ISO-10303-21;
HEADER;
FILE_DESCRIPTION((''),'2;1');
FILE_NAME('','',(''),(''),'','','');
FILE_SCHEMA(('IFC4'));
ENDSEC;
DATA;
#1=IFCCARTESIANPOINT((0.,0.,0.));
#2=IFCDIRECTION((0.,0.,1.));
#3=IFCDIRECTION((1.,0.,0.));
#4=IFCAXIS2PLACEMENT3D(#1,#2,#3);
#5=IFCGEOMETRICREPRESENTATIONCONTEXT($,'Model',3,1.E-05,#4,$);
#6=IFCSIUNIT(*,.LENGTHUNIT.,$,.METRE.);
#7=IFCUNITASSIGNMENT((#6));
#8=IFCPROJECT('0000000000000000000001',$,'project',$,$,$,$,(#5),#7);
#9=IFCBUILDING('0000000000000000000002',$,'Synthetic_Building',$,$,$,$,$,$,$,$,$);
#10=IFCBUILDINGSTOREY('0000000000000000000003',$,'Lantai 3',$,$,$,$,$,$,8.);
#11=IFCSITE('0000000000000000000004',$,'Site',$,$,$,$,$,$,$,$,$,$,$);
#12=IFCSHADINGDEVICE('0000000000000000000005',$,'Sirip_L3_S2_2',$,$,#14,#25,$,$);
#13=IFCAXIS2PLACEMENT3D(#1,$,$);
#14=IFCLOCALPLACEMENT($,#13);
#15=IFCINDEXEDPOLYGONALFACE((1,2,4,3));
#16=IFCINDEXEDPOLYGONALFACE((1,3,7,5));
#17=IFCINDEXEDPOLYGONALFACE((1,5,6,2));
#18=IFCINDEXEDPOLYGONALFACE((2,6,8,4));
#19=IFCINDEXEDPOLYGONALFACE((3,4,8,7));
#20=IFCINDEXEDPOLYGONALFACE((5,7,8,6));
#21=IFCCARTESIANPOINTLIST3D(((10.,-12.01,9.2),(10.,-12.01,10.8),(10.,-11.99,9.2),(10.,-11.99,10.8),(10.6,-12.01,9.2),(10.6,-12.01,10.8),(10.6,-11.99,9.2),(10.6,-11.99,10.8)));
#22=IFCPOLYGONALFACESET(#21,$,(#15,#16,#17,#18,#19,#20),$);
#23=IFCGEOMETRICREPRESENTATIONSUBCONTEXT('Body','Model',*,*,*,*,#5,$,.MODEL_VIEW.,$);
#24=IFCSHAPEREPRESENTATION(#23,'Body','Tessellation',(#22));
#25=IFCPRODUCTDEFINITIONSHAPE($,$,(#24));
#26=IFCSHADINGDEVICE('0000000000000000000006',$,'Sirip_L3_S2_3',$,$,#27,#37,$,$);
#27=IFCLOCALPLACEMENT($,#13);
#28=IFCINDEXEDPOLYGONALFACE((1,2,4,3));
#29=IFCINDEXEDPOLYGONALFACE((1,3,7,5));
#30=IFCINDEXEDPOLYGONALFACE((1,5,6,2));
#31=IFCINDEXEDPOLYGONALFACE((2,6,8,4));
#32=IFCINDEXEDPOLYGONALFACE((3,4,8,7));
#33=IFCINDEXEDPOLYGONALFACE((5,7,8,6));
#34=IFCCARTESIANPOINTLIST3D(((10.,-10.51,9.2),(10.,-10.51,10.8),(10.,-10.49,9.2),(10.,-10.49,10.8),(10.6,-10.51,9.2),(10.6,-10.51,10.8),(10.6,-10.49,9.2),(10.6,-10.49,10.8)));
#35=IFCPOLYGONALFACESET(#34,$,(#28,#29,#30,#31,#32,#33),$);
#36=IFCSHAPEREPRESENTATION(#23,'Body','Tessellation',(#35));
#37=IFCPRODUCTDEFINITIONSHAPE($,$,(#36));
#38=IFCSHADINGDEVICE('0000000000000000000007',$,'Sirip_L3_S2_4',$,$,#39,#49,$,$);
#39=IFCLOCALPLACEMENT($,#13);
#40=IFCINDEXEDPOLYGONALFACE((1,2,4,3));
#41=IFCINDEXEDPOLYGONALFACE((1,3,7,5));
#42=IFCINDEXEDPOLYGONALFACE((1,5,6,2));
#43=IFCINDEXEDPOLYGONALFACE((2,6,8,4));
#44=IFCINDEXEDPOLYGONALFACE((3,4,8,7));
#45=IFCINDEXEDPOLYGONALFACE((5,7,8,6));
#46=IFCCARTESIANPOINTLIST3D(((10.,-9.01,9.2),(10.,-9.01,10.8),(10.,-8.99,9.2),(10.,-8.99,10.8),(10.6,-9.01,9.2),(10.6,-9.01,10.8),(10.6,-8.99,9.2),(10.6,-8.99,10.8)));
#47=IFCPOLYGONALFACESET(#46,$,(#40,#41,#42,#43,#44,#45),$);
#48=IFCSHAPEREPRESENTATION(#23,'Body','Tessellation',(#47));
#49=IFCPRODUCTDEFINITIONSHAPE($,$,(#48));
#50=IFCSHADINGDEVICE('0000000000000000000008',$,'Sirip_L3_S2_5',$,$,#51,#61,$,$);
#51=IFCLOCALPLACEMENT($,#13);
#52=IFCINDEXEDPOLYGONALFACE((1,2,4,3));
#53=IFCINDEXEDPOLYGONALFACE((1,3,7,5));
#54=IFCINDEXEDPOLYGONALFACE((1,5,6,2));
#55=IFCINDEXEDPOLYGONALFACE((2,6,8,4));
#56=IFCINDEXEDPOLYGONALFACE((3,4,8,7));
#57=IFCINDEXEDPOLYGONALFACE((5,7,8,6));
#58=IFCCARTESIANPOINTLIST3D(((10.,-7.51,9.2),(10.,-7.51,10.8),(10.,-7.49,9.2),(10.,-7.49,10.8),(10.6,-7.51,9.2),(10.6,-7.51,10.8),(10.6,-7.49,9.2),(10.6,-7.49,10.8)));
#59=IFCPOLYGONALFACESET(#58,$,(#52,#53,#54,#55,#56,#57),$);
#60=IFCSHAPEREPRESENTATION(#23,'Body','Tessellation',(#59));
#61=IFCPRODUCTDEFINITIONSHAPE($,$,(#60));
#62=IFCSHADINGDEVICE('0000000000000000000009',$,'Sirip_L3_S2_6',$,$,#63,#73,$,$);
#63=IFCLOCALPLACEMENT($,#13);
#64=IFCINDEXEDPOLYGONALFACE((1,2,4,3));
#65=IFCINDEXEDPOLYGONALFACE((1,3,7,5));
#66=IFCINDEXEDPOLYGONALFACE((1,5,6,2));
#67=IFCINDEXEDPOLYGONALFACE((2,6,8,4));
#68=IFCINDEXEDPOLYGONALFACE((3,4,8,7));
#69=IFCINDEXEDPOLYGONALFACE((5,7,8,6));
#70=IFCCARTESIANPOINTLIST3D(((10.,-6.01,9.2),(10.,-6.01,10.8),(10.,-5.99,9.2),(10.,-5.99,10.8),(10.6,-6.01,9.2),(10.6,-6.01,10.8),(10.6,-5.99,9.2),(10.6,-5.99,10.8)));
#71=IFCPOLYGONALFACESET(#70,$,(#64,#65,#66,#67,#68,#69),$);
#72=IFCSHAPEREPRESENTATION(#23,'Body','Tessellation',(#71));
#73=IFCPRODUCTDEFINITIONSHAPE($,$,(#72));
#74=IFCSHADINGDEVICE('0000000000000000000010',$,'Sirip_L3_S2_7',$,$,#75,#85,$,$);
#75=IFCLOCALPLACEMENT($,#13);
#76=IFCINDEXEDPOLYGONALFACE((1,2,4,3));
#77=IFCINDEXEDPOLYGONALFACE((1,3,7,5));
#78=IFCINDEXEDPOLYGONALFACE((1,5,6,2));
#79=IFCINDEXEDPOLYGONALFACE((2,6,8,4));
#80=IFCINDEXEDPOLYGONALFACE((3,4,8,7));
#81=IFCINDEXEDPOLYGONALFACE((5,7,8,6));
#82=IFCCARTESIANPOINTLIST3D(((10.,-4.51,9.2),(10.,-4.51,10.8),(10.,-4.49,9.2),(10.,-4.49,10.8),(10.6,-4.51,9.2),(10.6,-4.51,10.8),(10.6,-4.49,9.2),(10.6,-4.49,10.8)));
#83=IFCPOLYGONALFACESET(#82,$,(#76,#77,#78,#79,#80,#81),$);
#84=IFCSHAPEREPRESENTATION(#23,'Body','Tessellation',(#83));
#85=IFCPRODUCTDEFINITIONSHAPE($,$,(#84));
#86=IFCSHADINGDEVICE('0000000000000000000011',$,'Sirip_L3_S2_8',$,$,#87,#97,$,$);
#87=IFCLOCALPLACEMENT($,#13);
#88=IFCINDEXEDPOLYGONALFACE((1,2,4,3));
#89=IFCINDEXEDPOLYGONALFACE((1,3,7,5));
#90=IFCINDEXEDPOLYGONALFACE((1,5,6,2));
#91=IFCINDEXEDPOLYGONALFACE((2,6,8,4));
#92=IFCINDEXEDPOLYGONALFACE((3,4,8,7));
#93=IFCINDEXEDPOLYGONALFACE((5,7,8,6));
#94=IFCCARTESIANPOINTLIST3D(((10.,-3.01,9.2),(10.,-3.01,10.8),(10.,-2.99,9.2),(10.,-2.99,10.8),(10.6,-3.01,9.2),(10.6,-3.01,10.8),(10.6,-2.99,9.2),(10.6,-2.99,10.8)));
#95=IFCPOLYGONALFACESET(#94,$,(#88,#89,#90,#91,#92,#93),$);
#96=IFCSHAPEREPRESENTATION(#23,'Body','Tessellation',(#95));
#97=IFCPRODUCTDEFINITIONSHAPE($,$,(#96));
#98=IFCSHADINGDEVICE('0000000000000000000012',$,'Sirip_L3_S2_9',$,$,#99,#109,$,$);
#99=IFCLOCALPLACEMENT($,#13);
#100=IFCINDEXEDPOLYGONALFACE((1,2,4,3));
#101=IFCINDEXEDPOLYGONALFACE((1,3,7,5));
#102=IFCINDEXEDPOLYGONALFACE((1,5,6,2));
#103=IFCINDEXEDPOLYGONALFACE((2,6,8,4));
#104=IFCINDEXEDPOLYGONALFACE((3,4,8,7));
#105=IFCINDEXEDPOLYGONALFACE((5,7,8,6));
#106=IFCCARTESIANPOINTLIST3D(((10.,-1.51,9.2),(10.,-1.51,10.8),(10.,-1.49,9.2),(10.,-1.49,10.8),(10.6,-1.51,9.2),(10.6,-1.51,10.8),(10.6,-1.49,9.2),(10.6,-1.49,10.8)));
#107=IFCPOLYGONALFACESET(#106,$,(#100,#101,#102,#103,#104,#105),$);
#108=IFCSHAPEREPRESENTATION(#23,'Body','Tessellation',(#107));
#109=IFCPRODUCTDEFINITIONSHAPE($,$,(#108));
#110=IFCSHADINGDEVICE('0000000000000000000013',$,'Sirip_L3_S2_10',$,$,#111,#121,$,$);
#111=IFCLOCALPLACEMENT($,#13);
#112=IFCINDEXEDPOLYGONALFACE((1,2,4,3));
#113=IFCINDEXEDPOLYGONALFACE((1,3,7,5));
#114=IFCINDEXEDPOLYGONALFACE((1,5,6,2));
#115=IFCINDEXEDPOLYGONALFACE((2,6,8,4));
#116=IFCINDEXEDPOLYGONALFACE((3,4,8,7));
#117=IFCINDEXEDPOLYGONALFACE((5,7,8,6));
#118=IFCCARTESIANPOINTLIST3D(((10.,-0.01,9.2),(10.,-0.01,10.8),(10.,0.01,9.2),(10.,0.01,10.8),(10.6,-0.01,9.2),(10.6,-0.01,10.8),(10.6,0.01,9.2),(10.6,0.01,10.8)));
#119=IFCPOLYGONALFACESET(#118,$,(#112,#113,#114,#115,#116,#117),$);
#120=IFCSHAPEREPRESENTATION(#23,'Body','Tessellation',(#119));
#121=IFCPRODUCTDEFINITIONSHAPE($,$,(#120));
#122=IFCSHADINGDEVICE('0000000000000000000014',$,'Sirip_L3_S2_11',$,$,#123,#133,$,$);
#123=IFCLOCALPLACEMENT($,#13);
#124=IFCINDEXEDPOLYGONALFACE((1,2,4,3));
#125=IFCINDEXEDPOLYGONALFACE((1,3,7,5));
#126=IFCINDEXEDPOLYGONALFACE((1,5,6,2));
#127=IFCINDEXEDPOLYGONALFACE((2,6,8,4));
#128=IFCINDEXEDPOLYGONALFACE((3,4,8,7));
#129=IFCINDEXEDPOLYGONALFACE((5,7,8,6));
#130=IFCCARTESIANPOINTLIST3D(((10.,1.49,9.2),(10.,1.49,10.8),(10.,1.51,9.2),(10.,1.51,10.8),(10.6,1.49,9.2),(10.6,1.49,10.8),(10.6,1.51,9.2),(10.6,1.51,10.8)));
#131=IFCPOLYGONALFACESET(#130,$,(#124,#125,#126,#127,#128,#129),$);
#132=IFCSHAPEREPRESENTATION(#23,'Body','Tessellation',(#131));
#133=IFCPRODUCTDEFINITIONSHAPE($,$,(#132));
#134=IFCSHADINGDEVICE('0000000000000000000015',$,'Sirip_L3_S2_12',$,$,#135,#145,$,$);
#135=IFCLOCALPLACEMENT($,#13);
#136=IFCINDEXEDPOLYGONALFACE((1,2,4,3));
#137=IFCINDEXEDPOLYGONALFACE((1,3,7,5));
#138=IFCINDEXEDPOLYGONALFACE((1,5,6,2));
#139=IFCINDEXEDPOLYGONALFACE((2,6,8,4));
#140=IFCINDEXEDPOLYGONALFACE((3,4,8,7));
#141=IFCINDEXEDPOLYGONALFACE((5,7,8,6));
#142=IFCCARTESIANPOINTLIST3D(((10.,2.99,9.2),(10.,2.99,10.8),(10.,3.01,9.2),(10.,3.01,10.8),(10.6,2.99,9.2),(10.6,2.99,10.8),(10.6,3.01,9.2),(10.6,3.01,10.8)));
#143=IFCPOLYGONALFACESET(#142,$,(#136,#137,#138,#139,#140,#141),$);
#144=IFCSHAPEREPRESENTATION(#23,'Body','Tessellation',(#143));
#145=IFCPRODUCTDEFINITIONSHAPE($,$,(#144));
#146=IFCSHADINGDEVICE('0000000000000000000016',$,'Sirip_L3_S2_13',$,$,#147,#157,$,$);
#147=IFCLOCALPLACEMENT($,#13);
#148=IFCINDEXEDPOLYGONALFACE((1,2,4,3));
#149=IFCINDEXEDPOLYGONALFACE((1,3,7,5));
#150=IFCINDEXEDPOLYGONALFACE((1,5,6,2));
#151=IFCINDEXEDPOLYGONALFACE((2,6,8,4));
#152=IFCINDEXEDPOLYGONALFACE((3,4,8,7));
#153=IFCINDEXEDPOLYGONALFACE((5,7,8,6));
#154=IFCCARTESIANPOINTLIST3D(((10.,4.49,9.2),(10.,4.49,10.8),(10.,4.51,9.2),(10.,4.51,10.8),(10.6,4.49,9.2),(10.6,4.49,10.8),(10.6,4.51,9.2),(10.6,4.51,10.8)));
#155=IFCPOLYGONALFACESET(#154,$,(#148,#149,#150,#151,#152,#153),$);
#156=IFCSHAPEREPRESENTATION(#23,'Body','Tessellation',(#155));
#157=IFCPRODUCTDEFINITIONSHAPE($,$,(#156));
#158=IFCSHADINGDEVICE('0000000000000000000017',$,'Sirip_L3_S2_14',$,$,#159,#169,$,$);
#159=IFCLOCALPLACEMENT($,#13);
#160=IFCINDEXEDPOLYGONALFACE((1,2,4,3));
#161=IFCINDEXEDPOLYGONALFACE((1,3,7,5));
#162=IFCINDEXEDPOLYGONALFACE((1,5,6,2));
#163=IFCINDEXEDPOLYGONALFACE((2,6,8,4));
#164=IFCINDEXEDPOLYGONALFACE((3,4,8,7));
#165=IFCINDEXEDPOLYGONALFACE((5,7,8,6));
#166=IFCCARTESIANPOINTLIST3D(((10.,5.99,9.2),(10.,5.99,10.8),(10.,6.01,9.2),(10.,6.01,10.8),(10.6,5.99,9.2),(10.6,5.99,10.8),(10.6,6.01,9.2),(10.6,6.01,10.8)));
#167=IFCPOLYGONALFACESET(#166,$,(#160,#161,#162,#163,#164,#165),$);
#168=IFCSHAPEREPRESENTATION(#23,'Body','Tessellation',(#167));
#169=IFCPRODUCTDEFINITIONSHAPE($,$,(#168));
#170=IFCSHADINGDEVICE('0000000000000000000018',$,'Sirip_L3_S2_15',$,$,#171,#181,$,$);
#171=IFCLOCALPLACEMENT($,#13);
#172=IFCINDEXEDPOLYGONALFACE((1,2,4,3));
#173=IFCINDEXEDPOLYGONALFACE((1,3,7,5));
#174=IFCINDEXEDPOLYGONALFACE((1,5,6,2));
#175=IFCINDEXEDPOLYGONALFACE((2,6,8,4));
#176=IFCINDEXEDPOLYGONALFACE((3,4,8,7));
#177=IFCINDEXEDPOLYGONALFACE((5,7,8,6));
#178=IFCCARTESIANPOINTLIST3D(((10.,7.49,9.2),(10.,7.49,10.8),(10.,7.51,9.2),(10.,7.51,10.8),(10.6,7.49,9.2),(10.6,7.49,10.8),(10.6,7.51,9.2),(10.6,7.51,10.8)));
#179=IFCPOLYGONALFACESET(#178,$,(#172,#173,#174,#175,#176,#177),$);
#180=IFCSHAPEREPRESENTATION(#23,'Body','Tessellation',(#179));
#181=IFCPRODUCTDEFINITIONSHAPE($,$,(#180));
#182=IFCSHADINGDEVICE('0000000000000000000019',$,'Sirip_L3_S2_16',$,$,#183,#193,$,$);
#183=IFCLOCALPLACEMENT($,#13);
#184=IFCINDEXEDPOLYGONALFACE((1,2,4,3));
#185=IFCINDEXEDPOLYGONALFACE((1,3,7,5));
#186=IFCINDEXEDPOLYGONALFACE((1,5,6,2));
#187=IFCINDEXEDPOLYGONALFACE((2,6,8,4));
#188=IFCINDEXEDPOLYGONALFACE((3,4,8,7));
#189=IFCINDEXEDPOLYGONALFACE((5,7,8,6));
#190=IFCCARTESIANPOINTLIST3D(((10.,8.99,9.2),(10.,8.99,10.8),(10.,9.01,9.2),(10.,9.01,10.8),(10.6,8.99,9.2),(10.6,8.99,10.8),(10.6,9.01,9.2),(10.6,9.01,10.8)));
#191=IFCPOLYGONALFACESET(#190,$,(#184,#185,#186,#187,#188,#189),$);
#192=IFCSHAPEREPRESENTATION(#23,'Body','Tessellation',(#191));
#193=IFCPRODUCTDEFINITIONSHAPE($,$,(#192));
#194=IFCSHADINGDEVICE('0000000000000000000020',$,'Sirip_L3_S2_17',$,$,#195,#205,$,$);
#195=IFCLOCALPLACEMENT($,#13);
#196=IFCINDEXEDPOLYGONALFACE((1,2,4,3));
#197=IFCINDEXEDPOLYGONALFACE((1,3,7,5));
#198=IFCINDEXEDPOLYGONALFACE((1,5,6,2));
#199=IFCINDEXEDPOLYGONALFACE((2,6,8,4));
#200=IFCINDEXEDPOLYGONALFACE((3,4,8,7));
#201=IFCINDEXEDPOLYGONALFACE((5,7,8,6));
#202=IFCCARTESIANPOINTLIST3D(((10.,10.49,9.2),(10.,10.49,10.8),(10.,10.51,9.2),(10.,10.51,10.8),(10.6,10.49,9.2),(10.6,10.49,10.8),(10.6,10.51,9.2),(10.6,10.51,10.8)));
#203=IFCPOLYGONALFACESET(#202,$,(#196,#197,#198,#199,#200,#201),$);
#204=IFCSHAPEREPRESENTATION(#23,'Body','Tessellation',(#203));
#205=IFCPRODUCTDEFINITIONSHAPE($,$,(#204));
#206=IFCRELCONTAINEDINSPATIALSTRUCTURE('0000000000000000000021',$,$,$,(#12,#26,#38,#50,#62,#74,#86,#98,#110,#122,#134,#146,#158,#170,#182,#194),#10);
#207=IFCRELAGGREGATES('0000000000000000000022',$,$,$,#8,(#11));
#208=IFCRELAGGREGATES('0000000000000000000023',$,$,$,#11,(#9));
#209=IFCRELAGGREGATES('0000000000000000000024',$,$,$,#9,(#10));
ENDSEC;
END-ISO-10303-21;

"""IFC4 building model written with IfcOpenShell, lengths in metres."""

from ifc_helpers import new_model, si_unit, frame, origin_with_axes, place, context, subcontext, project, spatial, polyline, outline, extrude, element, save


model = new_model("IFC4")

# Units and contexts
model_context = context("Model", 3, precision=1e-05, world=origin_with_axes())
body_context = subcontext(model_context, "Body", "Model", "MODEL_VIEW")
ifc_project = project(units=[si_unit("LENGTHUNIT", "METRE")], contexts=[model_context])

# Site, building, storey
site = spatial("IfcSite", under=ifc_project, Name="Site")
building = spatial("IfcBuilding", under=site, Name="Synthetic_Building")
storey = spatial("IfcBuildingStorey", under=building, Name="Lantai 3", Elevation=8.0)

# Shading devices
shading_device_1_placement = place(None, origin_with_axes())
element("IfcShadingDevice", 1, at=shading_device_1_placement, inside=storey, Name="Sirip_L3_S2_2", context=body_context, shape_type="SweptSolid", body=[
    extrude(outline(polyline([(10.0, -12.01), (10.0, -11.99), (10.6, -11.99), (10.6, -12.01), (10.0, -12.01)])), frame((0.0, 0.0, 9.2), z_axis=(0.0, 0.0, 1.0), x_axis=(1.0, 0.0, 0.0)), (0.0, 0.0, 1.0), 1.6),
])
shading_device_2_placement = place(None, origin_with_axes())
element("IfcShadingDevice", 2, at=shading_device_2_placement, inside=storey, Name="Sirip_L3_S2_3", context=body_context, shape_type="SweptSolid", body=[
    extrude(outline(polyline([(10.0, -10.51), (10.0, -10.49), (10.6, -10.49), (10.6, -10.51), (10.0, -10.51)])), frame((0.0, 0.0, 9.2), z_axis=(0.0, 0.0, 1.0), x_axis=(1.0, 0.0, 0.0)), (0.0, 0.0, 1.0), 1.6),
])
shading_device_3_placement = place(None, origin_with_axes())
element("IfcShadingDevice", 3, at=shading_device_3_placement, inside=storey, Name="Sirip_L3_S2_4", context=body_context, shape_type="SweptSolid", body=[
    extrude(outline(polyline([(10.0, -9.01), (10.0, -8.99), (10.6, -8.99), (10.6, -9.01), (10.0, -9.01)])), frame((0.0, 0.0, 9.2), z_axis=(0.0, 0.0, 1.0), x_axis=(1.0, 0.0, 0.0)), (0.0, 0.0, 1.0), 1.6),
])
shading_device_4_placement = place(None, origin_with_axes())
element("IfcShadingDevice", 4, at=shading_device_4_placement, inside=storey, Name="Sirip_L3_S2_5", context=body_context, shape_type="SweptSolid", body=[
    extrude(outline(polyline([(10.0, -7.51), (10.0, -7.49), (10.6, -7.49), (10.6, -7.51), (10.0, -7.51)])), frame((0.0, 0.0, 9.2), z_axis=(0.0, 0.0, 1.0), x_axis=(1.0, 0.0, 0.0)), (0.0, 0.0, 1.0), 1.6),
])
shading_device_5_placement = place(None, origin_with_axes())
element("IfcShadingDevice", 5, at=shading_device_5_placement, inside=storey, Name="Sirip_L3_S2_6", context=body_context, shape_type="SweptSolid", body=[
    extrude(outline(polyline([(10.0, -6.01), (10.0, -5.99), (10.6, -5.99), (10.6, -6.01), (10.0, -6.01)])), frame((0.0, 0.0, 9.2), z_axis=(0.0, 0.0, 1.0), x_axis=(1.0, 0.0, 0.0)), (0.0, 0.0, 1.0), 1.6),
])
shading_device_6_placement = place(None, origin_with_axes())
element("IfcShadingDevice", 6, at=shading_device_6_placement, inside=storey, Name="Sirip_L3_S2_7", context=body_context, shape_type="SweptSolid", body=[
    extrude(outline(polyline([(10.0, -4.51), (10.0, -4.49), (10.6, -4.49), (10.6, -4.51), (10.0, -4.51)])), frame((0.0, 0.0, 9.2), z_axis=(0.0, 0.0, 1.0), x_axis=(1.0, 0.0, 0.0)), (0.0, 0.0, 1.0), 1.6),
])
shading_device_7_placement = place(None, origin_with_axes())
element("IfcShadingDevice", 7, at=shading_device_7_placement, inside=storey, Name="Sirip_L3_S2_8", context=body_context, shape_type="SweptSolid", body=[
    extrude(outline(polyline([(10.0, -3.01), (10.0, -2.99), (10.6, -2.99), (10.6, -3.01), (10.0, -3.01)])), frame((0.0, 0.0, 9.2), z_axis=(0.0, 0.0, 1.0), x_axis=(1.0, 0.0, 0.0)), (0.0, 0.0, 1.0), 1.6),
])
shading_device_8_placement = place(None, origin_with_axes())
element("IfcShadingDevice", 8, at=shading_device_8_placement, inside=storey, Name="Sirip_L3_S2_9", context=body_context, shape_type="SweptSolid", body=[
    extrude(outline(polyline([(10.0, -1.51), (10.0, -1.49), (10.6, -1.49), (10.6, -1.51), (10.0, -1.51)])), frame((0.0, 0.0, 9.2), z_axis=(0.0, 0.0, 1.0), x_axis=(1.0, 0.0, 0.0)), (0.0, 0.0, 1.0), 1.6),
])
shading_device_9_placement = place(None, origin_with_axes())
element("IfcShadingDevice", 9, at=shading_device_9_placement, inside=storey, Name="Sirip_L3_S2_10", context=body_context, shape_type="SweptSolid", body=[
    extrude(outline(polyline([(10.0, -0.01), (10.0, 0.01), (10.6, 0.01), (10.6, -0.01), (10.0, -0.01)])), frame((0.0, 0.0, 9.2), z_axis=(0.0, 0.0, 1.0), x_axis=(1.0, 0.0, 0.0)), (0.0, 0.0, 1.0), 1.6),
])
shading_device_10_placement = place(None, origin_with_axes())
element("IfcShadingDevice", 10, at=shading_device_10_placement, inside=storey, Name="Sirip_L3_S2_11", context=body_context, shape_type="SweptSolid", body=[
    extrude(outline(polyline([(10.0, 1.49), (10.0, 1.51), (10.6, 1.51), (10.6, 1.49), (10.0, 1.49)])), frame((0.0, 0.0, 9.2), z_axis=(0.0, 0.0, 1.0), x_axis=(1.0, 0.0, 0.0)), (0.0, 0.0, 1.0), 1.6),
])
shading_device_11_placement = place(None, origin_with_axes())
element("IfcShadingDevice", 11, at=shading_device_11_placement, inside=storey, Name="Sirip_L3_S2_12", context=body_context, shape_type="SweptSolid", body=[
    extrude(outline(polyline([(10.0, 2.99), (10.0, 3.01), (10.6, 3.01), (10.6, 2.99), (10.0, 2.99)])), frame((0.0, 0.0, 9.2), z_axis=(0.0, 0.0, 1.0), x_axis=(1.0, 0.0, 0.0)), (0.0, 0.0, 1.0), 1.6),
])
shading_device_12_placement = place(None, origin_with_axes())
element("IfcShadingDevice", 12, at=shading_device_12_placement, inside=storey, Name="Sirip_L3_S2_13", context=body_context, shape_type="SweptSolid", body=[
    extrude(outline(polyline([(10.0, 4.49), (10.0, 4.51), (10.6, 4.51), (10.6, 4.49), (10.0, 4.49)])), frame((0.0, 0.0, 9.2), z_axis=(0.0, 0.0, 1.0), x_axis=(1.0, 0.0, 0.0)), (0.0, 0.0, 1.0), 1.6),
])
shading_device_13_placement = place(None, origin_with_axes())
element("IfcShadingDevice", 13, at=shading_device_13_placement, inside=storey, Name="Sirip_L3_S2_14", context=body_context, shape_type="SweptSolid", body=[
    extrude(outline(polyline([(10.0, 5.99), (10.0, 6.01), (10.6, 6.01), (10.6, 5.99), (10.0, 5.99)])), frame((0.0, 0.0, 9.2), z_axis=(0.0, 0.0, 1.0), x_axis=(1.0, 0.0, 0.0)), (0.0, 0.0, 1.0), 1.6),
])
shading_device_14_placement = place(None, origin_with_axes())
element("IfcShadingDevice", 14, at=shading_device_14_placement, inside=storey, Name="Sirip_L3_S2_15", context=body_context, shape_type="SweptSolid", body=[
    extrude(outline(polyline([(10.0, 7.49), (10.0, 7.51), (10.6, 7.51), (10.6, 7.49), (10.0, 7.49)])), frame((0.0, 0.0, 9.2), z_axis=(0.0, 0.0, 1.0), x_axis=(1.0, 0.0, 0.0)), (0.0, 0.0, 1.0), 1.6),
])
shading_device_15_placement = place(None, origin_with_axes())
element("IfcShadingDevice", 15, at=shading_device_15_placement, inside=storey, Name="Sirip_L3_S2_16", context=body_context, shape_type="SweptSolid", body=[
    extrude(outline(polyline([(10.0, 8.99), (10.0, 9.01), (10.6, 9.01), (10.6, 8.99), (10.0, 8.99)])), frame((0.0, 0.0, 9.2), z_axis=(0.0, 0.0, 1.0), x_axis=(1.0, 0.0, 0.0)), (0.0, 0.0, 1.0), 1.6),
])
shading_device_16_placement = place(None, origin_with_axes())
element("IfcShadingDevice", 16, at=shading_device_16_placement, inside=storey, Name="Sirip_L3_S2_17", context=body_context, shape_type="SweptSolid", body=[
    extrude(outline(polyline([(10.0, 10.49), (10.0, 10.51), (10.6, 10.51), (10.6, 10.49), (10.0, 10.49)])), frame((0.0, 0.0, 9.2), z_axis=(0.0, 0.0, 1.0), x_axis=(1.0, 0.0, 0.0)), (0.0, 0.0, 1.0), 1.6),
])

save(model, "model.ifc")
